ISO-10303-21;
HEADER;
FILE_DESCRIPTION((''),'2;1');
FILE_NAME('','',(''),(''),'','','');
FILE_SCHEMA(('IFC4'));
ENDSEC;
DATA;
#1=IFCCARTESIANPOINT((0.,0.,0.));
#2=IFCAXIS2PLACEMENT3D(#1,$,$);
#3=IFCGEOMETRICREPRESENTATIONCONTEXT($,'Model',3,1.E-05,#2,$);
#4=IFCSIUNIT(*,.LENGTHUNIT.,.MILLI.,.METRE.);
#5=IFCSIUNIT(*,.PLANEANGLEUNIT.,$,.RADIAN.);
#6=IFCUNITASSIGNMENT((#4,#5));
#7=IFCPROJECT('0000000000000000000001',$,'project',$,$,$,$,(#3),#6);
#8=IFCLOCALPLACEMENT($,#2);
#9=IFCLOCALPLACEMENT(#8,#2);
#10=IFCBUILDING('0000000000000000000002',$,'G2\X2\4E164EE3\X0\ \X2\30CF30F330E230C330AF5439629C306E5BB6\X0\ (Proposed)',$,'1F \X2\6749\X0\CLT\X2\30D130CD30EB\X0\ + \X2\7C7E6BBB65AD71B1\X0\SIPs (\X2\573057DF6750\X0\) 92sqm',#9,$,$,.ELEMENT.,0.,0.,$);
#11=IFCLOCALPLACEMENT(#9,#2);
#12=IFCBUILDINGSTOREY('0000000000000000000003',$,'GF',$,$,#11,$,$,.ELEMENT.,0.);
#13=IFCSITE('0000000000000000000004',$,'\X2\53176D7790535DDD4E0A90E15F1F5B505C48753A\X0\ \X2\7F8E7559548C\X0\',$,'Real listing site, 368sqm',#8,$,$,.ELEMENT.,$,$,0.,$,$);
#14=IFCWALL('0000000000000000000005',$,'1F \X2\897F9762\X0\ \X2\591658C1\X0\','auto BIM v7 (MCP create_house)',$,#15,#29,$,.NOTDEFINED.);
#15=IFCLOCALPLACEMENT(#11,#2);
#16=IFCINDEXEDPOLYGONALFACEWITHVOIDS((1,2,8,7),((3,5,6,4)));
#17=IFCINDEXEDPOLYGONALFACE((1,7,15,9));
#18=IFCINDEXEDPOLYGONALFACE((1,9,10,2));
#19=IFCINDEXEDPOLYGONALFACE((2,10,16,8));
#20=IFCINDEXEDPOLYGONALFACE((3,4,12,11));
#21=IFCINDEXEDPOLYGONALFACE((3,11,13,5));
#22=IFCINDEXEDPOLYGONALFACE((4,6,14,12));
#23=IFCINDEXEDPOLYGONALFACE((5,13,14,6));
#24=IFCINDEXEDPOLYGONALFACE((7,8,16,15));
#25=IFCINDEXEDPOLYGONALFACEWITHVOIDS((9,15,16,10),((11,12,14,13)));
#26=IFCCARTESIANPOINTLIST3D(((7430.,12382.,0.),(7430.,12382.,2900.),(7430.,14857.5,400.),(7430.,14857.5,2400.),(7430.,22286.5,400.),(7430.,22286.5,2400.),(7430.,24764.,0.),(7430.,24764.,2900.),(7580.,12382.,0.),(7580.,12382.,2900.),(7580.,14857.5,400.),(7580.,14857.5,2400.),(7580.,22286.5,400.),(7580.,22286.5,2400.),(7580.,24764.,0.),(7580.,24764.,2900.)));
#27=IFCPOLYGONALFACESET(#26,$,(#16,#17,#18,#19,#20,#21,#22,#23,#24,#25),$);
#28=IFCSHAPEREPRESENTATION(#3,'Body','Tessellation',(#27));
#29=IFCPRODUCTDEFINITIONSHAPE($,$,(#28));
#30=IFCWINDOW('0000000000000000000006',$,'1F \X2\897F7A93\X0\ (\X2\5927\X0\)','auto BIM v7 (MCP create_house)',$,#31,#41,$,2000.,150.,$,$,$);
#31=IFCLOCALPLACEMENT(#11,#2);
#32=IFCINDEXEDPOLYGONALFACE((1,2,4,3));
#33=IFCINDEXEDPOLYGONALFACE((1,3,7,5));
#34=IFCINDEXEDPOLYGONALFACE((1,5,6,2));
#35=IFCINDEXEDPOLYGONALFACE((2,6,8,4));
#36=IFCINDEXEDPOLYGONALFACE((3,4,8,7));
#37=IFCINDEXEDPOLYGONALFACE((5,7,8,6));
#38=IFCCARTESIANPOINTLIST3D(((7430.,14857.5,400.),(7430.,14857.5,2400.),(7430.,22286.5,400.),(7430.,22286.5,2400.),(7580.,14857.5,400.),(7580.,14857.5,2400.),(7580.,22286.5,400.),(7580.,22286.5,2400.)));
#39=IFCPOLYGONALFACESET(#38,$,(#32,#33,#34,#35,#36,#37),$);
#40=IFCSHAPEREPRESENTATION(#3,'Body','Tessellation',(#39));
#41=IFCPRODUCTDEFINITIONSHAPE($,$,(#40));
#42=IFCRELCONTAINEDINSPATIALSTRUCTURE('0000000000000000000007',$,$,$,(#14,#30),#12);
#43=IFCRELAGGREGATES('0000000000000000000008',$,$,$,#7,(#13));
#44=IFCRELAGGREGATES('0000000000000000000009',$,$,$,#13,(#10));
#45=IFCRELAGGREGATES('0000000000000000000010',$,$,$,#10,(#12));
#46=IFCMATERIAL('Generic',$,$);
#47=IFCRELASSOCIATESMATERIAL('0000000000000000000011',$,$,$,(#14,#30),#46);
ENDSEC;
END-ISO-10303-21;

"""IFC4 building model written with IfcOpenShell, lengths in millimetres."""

from ifc_helpers import new_model, si_unit, frame, frame_2d, origin, place, context, project, spatial, rectangle, extrude, material, element, fill, save


model = new_model("IFC4")

# Units and contexts
model_context = context("Model", 3, precision=1e-05, world=origin())
ifc_project = project(units=[si_unit("LENGTHUNIT", "METRE", prefix="MILLI"), si_unit("PLANEANGLEUNIT", "RADIAN")], contexts=[model_context])

# Site, building, storey
site_placement = place(None, origin())
site = spatial("IfcSite", under=ifc_project, at=site_placement, Name="北海道川上郡弟子屈町 美留和", ObjectType="Real listing site, 368sqm", CompositionType="ELEMENT", RefElevation=0.0)
building_placement = place(site_placement, origin())
building = spatial("IfcBuilding", under=site, at=building_placement, Name="G2世代 ハンモック吹抜の家 (Proposed)", ObjectType="1F 杉CLTパネル + 籾殻断熱SIPs (地域材) 92sqm", CompositionType="ELEMENT", ElevationOfRefHeight=0.0, ElevationOfTerrain=0.0)
storey_placement = place(building_placement, origin())
storey = spatial("IfcBuildingStorey", under=building, at=storey_placement, Name="GF", CompositionType="ELEMENT", Elevation=0.0)

# Shared definitions
ifc_material = material(Name="Generic")

# Wall, opening, window
wall_1_placement = place(storey_placement, frame((3715.0, 6191.0, 0.0)))
wall_1 = element("IfcWall", 1, at=wall_1_placement, inside=storey, material=ifc_material, Name="1F 西面 外壁", Description="auto BIM v7 (MCP create_house)", PredefinedType="NOTDEFINED", context=model_context, shape_type="SweptSolid", body=[
    extrude(rectangle(XDim=150.0, YDim=12382.0, at=frame_2d((75.0, 6191.0))), frame((3715.0, 6191.0, 0.0)), (0.0, 0.0, 1.0), 2900.0),
])
opening_1_placement = place(storey_placement, frame((3715.0, 7429.0, 200.0)))
opening_1 = element("IfcOpeningElement", 2, at=opening_1_placement, cuts=wall_1, PredefinedType="NOTDEFINED", context=model_context, shape_type="SweptSolid", body=[
    extrude(rectangle(XDim=150.0, YDim=7429.0, at=frame_2d((75.0, 3714.0))), frame((3715.0, 7429.0, 200.0)), (0.0, 0.0, 1.0), 2000.0),
])
window_1_placement = place(storey_placement, frame((3715.0, 7429.0, 200.0)))
window_1 = element("IfcWindow", 3, at=window_1_placement, inside=storey, material=ifc_material, Name="1F 西窓 (大)", Description="auto BIM v7 (MCP create_house)", OverallHeight=2000.0, OverallWidth=150.0, context=model_context, shape_type="SweptSolid", body=[
    extrude(rectangle(XDim=150.0, YDim=7429.0, at=frame_2d((75.0, 3714.0))), frame((3715.0, 7429.0, 200.0)), (0.0, 0.0, 1.0), 2000.0),
])
fill(opening_1, window_1)

save(model, "model.ifc")
